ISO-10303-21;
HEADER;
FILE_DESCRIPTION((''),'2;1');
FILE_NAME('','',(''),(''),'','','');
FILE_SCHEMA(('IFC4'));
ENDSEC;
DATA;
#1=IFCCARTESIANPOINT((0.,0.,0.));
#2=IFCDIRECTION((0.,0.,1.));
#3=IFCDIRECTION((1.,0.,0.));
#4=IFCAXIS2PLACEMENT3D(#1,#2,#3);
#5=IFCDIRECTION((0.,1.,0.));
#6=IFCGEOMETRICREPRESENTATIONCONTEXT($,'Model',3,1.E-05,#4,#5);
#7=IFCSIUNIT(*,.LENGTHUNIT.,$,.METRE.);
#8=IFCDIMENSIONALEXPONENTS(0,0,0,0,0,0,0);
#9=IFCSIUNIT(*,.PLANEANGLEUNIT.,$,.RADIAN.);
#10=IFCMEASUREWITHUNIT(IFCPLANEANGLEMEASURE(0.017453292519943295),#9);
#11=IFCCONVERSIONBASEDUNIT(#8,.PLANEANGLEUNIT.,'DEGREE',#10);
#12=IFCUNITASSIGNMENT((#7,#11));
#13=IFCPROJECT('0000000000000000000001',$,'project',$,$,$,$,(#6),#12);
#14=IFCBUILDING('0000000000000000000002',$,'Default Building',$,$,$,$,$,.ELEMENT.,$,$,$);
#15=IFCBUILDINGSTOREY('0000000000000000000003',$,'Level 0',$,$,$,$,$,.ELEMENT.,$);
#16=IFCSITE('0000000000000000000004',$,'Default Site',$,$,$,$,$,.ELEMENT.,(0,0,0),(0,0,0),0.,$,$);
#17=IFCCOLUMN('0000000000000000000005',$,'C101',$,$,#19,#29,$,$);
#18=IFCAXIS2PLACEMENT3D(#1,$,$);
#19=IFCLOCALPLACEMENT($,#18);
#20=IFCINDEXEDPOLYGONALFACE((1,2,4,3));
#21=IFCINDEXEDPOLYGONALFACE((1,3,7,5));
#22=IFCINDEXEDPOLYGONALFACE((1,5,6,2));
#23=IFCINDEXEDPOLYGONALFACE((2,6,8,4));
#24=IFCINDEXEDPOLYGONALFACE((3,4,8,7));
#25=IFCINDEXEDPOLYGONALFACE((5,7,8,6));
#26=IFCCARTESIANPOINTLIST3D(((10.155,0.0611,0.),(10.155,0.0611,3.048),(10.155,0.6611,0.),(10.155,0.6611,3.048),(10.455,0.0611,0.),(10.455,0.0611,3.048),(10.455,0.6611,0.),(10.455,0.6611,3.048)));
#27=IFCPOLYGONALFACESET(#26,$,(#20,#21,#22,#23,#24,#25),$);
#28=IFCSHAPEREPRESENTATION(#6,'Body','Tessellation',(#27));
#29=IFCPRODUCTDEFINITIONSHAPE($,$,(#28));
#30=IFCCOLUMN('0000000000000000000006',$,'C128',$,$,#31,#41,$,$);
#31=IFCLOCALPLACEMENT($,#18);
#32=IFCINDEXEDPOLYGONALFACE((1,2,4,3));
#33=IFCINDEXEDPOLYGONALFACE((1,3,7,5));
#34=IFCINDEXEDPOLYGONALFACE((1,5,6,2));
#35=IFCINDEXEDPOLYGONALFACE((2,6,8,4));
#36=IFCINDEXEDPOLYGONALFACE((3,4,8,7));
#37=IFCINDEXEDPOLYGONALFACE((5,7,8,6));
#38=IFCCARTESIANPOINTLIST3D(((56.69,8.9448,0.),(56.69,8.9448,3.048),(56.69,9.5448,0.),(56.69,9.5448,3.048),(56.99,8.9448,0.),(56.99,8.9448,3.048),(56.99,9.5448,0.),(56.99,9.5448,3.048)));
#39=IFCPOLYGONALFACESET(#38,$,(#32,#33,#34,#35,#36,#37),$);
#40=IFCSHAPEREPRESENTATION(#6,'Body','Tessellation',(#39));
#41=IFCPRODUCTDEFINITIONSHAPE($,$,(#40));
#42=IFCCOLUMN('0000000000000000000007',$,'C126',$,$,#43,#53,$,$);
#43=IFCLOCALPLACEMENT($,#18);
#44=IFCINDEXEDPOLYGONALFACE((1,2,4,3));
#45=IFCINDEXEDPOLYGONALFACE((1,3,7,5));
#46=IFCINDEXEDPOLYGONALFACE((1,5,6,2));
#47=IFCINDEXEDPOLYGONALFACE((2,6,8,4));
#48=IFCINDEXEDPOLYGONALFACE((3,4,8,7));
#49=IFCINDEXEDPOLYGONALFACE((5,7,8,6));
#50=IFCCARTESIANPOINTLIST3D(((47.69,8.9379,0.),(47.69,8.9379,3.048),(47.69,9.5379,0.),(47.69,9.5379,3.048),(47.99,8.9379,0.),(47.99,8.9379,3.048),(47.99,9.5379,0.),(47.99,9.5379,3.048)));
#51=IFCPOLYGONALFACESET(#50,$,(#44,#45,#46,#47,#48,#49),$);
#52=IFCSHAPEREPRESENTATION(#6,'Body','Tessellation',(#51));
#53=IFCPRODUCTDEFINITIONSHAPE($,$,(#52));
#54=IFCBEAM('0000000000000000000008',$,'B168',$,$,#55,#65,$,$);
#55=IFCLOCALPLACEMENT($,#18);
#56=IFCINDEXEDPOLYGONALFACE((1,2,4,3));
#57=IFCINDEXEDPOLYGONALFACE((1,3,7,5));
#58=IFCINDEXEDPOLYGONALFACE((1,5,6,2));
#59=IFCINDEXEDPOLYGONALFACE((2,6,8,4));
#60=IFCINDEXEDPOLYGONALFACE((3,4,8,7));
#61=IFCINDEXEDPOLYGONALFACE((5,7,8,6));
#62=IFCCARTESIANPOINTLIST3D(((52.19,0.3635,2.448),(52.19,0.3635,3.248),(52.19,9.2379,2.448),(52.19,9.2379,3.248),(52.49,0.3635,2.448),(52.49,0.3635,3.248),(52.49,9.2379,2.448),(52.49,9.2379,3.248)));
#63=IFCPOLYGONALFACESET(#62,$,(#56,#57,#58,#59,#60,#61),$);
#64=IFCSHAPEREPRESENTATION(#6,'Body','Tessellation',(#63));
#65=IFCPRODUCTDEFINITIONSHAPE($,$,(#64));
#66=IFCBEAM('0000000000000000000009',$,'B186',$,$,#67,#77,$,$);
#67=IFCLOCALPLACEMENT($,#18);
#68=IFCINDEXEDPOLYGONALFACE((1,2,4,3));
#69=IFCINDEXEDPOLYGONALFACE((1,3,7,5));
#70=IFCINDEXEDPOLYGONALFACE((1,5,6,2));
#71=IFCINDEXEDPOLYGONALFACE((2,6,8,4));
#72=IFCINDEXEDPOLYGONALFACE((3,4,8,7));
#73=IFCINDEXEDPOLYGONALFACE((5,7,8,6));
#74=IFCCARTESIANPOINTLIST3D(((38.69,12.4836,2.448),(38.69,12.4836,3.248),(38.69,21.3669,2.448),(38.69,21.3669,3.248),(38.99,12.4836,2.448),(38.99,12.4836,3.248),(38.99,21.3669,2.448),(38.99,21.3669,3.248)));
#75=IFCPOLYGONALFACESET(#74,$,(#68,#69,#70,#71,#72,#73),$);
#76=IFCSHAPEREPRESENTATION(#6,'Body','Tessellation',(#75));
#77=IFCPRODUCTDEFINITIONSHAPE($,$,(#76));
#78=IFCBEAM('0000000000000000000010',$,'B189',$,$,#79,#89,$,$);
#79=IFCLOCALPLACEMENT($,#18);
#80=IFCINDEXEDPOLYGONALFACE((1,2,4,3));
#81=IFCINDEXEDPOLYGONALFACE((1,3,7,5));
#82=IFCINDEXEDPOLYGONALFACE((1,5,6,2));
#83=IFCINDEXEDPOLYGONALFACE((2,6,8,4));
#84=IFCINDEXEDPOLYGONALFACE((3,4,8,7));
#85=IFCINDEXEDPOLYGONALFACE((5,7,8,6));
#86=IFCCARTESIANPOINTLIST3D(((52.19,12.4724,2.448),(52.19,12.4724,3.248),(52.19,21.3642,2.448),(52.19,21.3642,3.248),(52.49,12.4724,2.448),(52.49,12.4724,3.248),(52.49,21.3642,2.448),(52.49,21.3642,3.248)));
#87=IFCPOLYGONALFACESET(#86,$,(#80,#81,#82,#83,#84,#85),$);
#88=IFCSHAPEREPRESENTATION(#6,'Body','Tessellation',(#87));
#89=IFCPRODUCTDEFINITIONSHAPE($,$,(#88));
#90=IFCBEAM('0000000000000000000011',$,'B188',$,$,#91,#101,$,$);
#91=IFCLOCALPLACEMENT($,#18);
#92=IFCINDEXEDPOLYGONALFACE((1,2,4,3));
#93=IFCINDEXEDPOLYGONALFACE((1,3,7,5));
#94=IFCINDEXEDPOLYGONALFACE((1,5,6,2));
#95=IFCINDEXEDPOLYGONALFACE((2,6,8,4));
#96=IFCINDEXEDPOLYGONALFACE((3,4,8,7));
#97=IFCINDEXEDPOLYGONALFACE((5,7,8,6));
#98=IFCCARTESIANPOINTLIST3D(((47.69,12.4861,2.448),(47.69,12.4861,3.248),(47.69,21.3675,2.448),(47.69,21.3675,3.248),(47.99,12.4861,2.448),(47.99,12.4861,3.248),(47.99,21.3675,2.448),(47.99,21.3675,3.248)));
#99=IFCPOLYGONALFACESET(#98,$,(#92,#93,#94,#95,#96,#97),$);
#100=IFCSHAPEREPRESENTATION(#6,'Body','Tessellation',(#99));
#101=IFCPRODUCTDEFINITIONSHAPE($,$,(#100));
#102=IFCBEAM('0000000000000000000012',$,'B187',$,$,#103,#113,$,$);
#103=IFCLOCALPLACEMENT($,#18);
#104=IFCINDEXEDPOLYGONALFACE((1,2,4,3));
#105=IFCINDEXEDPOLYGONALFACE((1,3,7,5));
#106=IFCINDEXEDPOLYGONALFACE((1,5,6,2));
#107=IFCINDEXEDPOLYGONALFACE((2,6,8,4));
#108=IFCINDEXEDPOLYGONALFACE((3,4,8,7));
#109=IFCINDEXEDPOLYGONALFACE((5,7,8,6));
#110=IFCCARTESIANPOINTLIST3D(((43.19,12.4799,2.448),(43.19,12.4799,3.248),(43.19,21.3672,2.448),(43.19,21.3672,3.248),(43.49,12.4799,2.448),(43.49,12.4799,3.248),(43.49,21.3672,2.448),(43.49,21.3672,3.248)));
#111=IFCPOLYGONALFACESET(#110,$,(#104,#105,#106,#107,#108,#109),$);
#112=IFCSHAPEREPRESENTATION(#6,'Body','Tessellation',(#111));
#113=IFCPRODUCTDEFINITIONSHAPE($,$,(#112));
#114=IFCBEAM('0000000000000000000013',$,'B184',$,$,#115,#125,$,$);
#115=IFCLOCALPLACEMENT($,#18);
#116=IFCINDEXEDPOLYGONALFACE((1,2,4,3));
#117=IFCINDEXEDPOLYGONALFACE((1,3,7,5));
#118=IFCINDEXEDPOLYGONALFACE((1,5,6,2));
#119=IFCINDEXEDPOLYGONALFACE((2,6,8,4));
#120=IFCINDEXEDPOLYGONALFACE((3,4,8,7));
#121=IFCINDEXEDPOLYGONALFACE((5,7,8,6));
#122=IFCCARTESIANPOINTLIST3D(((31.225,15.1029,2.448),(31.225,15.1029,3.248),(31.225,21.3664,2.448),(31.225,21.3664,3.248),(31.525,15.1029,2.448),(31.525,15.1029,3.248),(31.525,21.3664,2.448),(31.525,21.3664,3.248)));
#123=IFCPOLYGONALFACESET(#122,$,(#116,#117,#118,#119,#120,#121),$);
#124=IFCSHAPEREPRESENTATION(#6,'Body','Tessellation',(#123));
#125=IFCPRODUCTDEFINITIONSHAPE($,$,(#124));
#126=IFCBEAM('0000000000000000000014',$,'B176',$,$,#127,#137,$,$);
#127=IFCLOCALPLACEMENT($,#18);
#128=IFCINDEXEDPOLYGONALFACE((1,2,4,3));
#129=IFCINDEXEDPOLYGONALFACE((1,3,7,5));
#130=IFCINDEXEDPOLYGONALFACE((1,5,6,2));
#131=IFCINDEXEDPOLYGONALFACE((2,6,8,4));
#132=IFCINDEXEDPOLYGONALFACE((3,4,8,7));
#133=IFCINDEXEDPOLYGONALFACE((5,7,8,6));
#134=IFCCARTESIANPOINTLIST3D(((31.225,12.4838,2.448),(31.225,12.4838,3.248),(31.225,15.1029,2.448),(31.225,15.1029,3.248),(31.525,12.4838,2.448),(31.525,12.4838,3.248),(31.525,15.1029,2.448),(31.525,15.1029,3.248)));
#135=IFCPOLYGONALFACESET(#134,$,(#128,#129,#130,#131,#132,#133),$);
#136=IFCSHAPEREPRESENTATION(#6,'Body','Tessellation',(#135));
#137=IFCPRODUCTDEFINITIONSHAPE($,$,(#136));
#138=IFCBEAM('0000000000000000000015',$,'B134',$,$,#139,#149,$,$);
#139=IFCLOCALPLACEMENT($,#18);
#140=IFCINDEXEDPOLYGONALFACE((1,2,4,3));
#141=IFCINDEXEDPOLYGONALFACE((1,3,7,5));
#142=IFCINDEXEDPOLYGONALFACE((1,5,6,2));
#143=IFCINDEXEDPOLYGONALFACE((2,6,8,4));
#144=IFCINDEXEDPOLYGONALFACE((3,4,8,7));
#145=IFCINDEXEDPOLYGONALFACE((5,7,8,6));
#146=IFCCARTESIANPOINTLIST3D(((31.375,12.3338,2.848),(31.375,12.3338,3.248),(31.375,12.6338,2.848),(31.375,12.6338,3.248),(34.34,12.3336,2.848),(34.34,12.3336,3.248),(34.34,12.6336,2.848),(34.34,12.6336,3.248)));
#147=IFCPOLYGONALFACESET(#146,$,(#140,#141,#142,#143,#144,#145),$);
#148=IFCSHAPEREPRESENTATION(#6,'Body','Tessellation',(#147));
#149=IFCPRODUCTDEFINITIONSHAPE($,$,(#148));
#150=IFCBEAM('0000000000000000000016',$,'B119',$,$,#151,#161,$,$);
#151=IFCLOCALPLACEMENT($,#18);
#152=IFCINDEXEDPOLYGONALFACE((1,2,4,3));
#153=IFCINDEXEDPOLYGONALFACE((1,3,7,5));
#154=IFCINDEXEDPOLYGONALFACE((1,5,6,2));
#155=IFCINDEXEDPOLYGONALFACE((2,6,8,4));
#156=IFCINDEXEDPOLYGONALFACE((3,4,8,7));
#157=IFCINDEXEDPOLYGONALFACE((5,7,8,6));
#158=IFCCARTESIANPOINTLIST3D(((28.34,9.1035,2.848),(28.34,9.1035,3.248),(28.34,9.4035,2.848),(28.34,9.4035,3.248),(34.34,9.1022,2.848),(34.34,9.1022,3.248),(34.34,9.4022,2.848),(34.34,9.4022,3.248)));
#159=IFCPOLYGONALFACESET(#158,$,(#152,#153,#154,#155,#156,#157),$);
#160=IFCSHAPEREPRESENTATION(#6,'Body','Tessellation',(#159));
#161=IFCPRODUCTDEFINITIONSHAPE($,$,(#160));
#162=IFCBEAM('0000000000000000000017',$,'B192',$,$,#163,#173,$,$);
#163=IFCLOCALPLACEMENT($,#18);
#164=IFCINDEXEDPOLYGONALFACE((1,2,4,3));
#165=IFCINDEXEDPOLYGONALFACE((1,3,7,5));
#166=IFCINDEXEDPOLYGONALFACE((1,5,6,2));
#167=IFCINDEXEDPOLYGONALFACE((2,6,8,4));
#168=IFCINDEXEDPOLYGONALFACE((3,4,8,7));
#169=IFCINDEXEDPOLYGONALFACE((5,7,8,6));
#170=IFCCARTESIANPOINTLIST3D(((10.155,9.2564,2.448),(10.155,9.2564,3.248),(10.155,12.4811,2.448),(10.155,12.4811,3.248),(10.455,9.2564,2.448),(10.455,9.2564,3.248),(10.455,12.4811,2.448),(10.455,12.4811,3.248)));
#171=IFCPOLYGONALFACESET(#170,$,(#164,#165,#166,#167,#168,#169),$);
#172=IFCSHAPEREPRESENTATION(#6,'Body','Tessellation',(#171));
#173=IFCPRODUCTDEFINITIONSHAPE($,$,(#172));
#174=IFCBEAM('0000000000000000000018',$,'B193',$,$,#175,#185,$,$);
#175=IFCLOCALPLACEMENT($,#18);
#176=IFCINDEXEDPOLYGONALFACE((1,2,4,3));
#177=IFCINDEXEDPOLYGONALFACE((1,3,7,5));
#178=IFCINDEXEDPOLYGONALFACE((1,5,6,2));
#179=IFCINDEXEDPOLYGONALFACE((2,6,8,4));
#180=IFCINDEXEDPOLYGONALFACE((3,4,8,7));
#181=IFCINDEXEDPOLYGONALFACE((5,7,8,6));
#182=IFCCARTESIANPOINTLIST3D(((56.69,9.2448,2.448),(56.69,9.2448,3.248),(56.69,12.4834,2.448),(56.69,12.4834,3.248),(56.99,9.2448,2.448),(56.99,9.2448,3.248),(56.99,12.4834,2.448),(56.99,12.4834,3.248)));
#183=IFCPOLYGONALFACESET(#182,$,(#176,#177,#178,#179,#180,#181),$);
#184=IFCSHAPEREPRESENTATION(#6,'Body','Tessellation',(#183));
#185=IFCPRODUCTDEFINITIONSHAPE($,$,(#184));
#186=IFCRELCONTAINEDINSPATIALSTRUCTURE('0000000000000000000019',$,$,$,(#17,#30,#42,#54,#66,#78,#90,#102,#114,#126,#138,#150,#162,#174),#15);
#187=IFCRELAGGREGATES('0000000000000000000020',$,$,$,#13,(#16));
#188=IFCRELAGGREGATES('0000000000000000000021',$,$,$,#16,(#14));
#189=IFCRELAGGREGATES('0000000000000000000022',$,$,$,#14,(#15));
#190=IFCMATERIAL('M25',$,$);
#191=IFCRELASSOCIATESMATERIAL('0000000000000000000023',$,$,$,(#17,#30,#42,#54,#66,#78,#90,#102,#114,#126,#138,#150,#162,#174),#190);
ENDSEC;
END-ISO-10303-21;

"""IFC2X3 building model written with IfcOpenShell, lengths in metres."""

from ifc_helpers import new_model, entity, si_unit, converted_unit, direction, frame, frame_2d, origin_with_axes, place, context, project, spatial, rectangle, extrude, material, element, save


model = new_model("IFC2X3")

# Units and contexts
model_context = context("Model", 3, precision=1e-05, world=origin_with_axes(), true_north=direction((0.0, 1.0, 0.0)))
ifc_project = project(units=[si_unit("LENGTHUNIT", "METRE"), converted_unit("PLANEANGLEUNIT", "DEGREE", entity("IfcPlaneAngleMeasure", 0.017453292519943295), si_unit("PLANEANGLEUNIT", "RADIAN"), dimensions=[0, 0, 0, 0, 0, 0, 0])], contexts=[model_context])

# Site, building, storey
site = spatial("IfcSite", under=ifc_project, Name="Default Site", CompositionType="ELEMENT", RefLatitude=(0, 0, 0), RefLongitude=(0, 0, 0), RefElevation=0.0)
building = spatial("IfcBuilding", under=site, Name="Default Building", CompositionType="ELEMENT")
storey = spatial("IfcBuildingStorey", under=building, Name="Level 0", CompositionType="ELEMENT")

# Columns
ifc_material = material(Name="M25")
placement = place(None, origin_with_axes())
element("IfcColumn", 1, at=placement, inside=storey, material=ifc_material, Name="C101", context=model_context, shape_type="SweptSolid", body=[
    extrude(rectangle(XDim=0.3, YDim=0.6, at=frame_2d((0.0, 0.0), x_axis=(1.0, 0.0, 0.0))), frame((10.305, 0.3611, 0.0), z_axis=(0.0, 0.0, 1.0), x_axis=(1.0, 0.0, 0.0)), (0.0, 0.0, 1.0), 3.048),
])
element("IfcColumn", 2, at=placement, inside=storey, material=ifc_material, Name="C128", context=model_context, shape_type="SweptSolid", body=[
    extrude(rectangle(XDim=0.3, YDim=0.6, at=frame_2d((0.0, 0.0), x_axis=(1.0, 0.0, 0.0))), frame((56.84, 9.2448, 0.0), z_axis=(0.0, 0.0, 1.0), x_axis=(1.0, 0.0, 0.0)), (0.0, 0.0, 1.0), 3.048),
])
element("IfcColumn", 3, at=placement, inside=storey, material=ifc_material, Name="C126", context=model_context, shape_type="SweptSolid", body=[
    extrude(rectangle(XDim=0.3, YDim=0.6, at=frame_2d((0.0, 0.0), x_axis=(1.0, 0.0, 0.0))), frame((47.84, 9.2379, 0.0), z_axis=(0.0, 0.0, 1.0), x_axis=(1.0, 0.0, 0.0)), (0.0, 0.0, 1.0), 3.048),
])

# Beams
element("IfcBeam", 4, at=placement, inside=storey, material=ifc_material, Name="B168", context=model_context, shape_type="SweptSolid", body=[
    extrude(rectangle(XDim=0.3, YDim=0.8, at=frame_2d((0.0, 0.0), x_axis=(0.0, 1.0, 0.0))), frame((52.34, 0.3635, 2.848), z_axis=(0.0, 1.0, 0.0), x_axis=(0.0, 0.0, -1.0)), (0.0, 0.0, 1.0), 8.8744),
])
element("IfcBeam", 5, at=placement, inside=storey, material=ifc_material, Name="B186", context=model_context, shape_type="SweptSolid", body=[
    extrude(rectangle(XDim=0.3, YDim=0.8, at=frame_2d((0.0, 0.0), x_axis=(0.0, 1.0, 0.0))), frame((38.84, 21.3669, 2.848), z_axis=(0.0, -1.0, 0.0), x_axis=(0.0, 0.0, -1.0)), (0.0, 0.0, 1.0), 8.8833),
])
element("IfcBeam", 6, at=placement, inside=storey, material=ifc_material, Name="B189", context=model_context, shape_type="SweptSolid", body=[
    extrude(rectangle(XDim=0.3, YDim=0.8, at=frame_2d((0.0, 0.0), x_axis=(0.0, 1.0, 0.0))), frame((52.34, 12.4724, 2.848), z_axis=(0.0, 1.0, 0.0), x_axis=(0.0, 0.0, -1.0)), (0.0, 0.0, 1.0), 8.8918),
])
element("IfcBeam", 7, at=placement, inside=storey, material=ifc_material, Name="B188", context=model_context, shape_type="SweptSolid", body=[
    extrude(rectangle(XDim=0.3, YDim=0.8, at=frame_2d((0.0, 0.0), x_axis=(0.0, 1.0, 0.0))), frame((47.84, 12.4861, 2.848), z_axis=(0.0, 1.0, 0.0), x_axis=(0.0, 0.0, -1.0)), (0.0, 0.0, 1.0), 8.8814),
])
element("IfcBeam", 8, at=placement, inside=storey, material=ifc_material, Name="B187", context=model_context, shape_type="SweptSolid", body=[
    extrude(rectangle(XDim=0.3, YDim=0.8, at=frame_2d((0.0, 0.0), x_axis=(0.0, 1.0, 0.0))), frame((43.34, 21.3672, 2.848), z_axis=(0.0, -1.0, 0.0), x_axis=(0.0, 0.0, -1.0)), (0.0, 0.0, 1.0), 8.8873),
])
element("IfcBeam", 9, at=placement, inside=storey, material=ifc_material, Name="B184", context=model_context, shape_type="SweptSolid", body=[
    extrude(rectangle(XDim=0.3, YDim=0.8, at=frame_2d((0.0, 0.0), x_axis=(0.0, 1.0, 0.0))), frame((31.375, 21.3664, 2.848), z_axis=(0.0, -1.0, 0.0), x_axis=(0.0, 0.0, -1.0)), (0.0, 0.0, 1.0), 6.2635),
])
element("IfcBeam", 10, at=placement, inside=storey, material=ifc_material, Name="B176", context=model_context, shape_type="SweptSolid", body=[
    extrude(rectangle(XDim=0.3, YDim=0.8, at=frame_2d((0.0, 0.0), x_axis=(0.0, 1.0, 0.0))), frame((31.375, 15.1029, 2.848), z_axis=(0.0, -1.0, 0.0), x_axis=(0.0, 0.0, -1.0)), (0.0, 0.0, 1.0), 2.6191),
])
element("IfcBeam", 11, at=placement, inside=storey, material=ifc_material, Name="B134", context=model_context, shape_type="SweptSolid", body=[
    extrude(rectangle(XDim=0.3, YDim=0.4, at=frame_2d((0.0, 0.0), x_axis=(0.0, 1.0, 0.0))), frame((31.375, 12.4838, 3.048), z_axis=(1.0, -0.000067, 0.0), x_axis=(0.0, 0.0, -1.0)), (0.0, 0.0, 1.0), 2.965),
])
element("IfcBeam", 12, at=placement, inside=storey, material=ifc_material, Name="B119", context=model_context, shape_type="SweptSolid", body=[
    extrude(rectangle(XDim=0.3, YDim=0.4, at=frame_2d((0.0, 0.0), x_axis=(0.0, 1.0, 0.0))), frame((28.34, 9.2535, 3.048), z_axis=(1.0, -0.000213, 0.0), x_axis=(0.0, 0.0, -1.0)), (0.0, 0.0, 1.0), 6.0),
])
element("IfcBeam", 13, at=placement, inside=storey, material=ifc_material, Name="B192", context=model_context, shape_type="SweptSolid", body=[
    extrude(rectangle(XDim=0.3, YDim=0.8, at=frame_2d((0.0, 0.0), x_axis=(0.0, 1.0, 0.0))), frame((10.305, 12.4811, 2.848), z_axis=(0.0, -1.0, 0.0), x_axis=(0.0, 0.0, -1.0)), (0.0, 0.0, 1.0), 3.2247),
])
element("IfcBeam", 14, at=placement, inside=storey, material=ifc_material, Name="B193", context=model_context, shape_type="SweptSolid", body=[
    extrude(rectangle(XDim=0.3, YDim=0.8, at=frame_2d((0.0, 0.0), x_axis=(0.0, 1.0, 0.0))), frame((56.84, 12.4834, 2.848), z_axis=(0.0, -1.0, 0.0), x_axis=(0.0, 0.0, -1.0)), (0.0, 0.0, 1.0), 3.2386),
])

save(model, "model.ifc")
